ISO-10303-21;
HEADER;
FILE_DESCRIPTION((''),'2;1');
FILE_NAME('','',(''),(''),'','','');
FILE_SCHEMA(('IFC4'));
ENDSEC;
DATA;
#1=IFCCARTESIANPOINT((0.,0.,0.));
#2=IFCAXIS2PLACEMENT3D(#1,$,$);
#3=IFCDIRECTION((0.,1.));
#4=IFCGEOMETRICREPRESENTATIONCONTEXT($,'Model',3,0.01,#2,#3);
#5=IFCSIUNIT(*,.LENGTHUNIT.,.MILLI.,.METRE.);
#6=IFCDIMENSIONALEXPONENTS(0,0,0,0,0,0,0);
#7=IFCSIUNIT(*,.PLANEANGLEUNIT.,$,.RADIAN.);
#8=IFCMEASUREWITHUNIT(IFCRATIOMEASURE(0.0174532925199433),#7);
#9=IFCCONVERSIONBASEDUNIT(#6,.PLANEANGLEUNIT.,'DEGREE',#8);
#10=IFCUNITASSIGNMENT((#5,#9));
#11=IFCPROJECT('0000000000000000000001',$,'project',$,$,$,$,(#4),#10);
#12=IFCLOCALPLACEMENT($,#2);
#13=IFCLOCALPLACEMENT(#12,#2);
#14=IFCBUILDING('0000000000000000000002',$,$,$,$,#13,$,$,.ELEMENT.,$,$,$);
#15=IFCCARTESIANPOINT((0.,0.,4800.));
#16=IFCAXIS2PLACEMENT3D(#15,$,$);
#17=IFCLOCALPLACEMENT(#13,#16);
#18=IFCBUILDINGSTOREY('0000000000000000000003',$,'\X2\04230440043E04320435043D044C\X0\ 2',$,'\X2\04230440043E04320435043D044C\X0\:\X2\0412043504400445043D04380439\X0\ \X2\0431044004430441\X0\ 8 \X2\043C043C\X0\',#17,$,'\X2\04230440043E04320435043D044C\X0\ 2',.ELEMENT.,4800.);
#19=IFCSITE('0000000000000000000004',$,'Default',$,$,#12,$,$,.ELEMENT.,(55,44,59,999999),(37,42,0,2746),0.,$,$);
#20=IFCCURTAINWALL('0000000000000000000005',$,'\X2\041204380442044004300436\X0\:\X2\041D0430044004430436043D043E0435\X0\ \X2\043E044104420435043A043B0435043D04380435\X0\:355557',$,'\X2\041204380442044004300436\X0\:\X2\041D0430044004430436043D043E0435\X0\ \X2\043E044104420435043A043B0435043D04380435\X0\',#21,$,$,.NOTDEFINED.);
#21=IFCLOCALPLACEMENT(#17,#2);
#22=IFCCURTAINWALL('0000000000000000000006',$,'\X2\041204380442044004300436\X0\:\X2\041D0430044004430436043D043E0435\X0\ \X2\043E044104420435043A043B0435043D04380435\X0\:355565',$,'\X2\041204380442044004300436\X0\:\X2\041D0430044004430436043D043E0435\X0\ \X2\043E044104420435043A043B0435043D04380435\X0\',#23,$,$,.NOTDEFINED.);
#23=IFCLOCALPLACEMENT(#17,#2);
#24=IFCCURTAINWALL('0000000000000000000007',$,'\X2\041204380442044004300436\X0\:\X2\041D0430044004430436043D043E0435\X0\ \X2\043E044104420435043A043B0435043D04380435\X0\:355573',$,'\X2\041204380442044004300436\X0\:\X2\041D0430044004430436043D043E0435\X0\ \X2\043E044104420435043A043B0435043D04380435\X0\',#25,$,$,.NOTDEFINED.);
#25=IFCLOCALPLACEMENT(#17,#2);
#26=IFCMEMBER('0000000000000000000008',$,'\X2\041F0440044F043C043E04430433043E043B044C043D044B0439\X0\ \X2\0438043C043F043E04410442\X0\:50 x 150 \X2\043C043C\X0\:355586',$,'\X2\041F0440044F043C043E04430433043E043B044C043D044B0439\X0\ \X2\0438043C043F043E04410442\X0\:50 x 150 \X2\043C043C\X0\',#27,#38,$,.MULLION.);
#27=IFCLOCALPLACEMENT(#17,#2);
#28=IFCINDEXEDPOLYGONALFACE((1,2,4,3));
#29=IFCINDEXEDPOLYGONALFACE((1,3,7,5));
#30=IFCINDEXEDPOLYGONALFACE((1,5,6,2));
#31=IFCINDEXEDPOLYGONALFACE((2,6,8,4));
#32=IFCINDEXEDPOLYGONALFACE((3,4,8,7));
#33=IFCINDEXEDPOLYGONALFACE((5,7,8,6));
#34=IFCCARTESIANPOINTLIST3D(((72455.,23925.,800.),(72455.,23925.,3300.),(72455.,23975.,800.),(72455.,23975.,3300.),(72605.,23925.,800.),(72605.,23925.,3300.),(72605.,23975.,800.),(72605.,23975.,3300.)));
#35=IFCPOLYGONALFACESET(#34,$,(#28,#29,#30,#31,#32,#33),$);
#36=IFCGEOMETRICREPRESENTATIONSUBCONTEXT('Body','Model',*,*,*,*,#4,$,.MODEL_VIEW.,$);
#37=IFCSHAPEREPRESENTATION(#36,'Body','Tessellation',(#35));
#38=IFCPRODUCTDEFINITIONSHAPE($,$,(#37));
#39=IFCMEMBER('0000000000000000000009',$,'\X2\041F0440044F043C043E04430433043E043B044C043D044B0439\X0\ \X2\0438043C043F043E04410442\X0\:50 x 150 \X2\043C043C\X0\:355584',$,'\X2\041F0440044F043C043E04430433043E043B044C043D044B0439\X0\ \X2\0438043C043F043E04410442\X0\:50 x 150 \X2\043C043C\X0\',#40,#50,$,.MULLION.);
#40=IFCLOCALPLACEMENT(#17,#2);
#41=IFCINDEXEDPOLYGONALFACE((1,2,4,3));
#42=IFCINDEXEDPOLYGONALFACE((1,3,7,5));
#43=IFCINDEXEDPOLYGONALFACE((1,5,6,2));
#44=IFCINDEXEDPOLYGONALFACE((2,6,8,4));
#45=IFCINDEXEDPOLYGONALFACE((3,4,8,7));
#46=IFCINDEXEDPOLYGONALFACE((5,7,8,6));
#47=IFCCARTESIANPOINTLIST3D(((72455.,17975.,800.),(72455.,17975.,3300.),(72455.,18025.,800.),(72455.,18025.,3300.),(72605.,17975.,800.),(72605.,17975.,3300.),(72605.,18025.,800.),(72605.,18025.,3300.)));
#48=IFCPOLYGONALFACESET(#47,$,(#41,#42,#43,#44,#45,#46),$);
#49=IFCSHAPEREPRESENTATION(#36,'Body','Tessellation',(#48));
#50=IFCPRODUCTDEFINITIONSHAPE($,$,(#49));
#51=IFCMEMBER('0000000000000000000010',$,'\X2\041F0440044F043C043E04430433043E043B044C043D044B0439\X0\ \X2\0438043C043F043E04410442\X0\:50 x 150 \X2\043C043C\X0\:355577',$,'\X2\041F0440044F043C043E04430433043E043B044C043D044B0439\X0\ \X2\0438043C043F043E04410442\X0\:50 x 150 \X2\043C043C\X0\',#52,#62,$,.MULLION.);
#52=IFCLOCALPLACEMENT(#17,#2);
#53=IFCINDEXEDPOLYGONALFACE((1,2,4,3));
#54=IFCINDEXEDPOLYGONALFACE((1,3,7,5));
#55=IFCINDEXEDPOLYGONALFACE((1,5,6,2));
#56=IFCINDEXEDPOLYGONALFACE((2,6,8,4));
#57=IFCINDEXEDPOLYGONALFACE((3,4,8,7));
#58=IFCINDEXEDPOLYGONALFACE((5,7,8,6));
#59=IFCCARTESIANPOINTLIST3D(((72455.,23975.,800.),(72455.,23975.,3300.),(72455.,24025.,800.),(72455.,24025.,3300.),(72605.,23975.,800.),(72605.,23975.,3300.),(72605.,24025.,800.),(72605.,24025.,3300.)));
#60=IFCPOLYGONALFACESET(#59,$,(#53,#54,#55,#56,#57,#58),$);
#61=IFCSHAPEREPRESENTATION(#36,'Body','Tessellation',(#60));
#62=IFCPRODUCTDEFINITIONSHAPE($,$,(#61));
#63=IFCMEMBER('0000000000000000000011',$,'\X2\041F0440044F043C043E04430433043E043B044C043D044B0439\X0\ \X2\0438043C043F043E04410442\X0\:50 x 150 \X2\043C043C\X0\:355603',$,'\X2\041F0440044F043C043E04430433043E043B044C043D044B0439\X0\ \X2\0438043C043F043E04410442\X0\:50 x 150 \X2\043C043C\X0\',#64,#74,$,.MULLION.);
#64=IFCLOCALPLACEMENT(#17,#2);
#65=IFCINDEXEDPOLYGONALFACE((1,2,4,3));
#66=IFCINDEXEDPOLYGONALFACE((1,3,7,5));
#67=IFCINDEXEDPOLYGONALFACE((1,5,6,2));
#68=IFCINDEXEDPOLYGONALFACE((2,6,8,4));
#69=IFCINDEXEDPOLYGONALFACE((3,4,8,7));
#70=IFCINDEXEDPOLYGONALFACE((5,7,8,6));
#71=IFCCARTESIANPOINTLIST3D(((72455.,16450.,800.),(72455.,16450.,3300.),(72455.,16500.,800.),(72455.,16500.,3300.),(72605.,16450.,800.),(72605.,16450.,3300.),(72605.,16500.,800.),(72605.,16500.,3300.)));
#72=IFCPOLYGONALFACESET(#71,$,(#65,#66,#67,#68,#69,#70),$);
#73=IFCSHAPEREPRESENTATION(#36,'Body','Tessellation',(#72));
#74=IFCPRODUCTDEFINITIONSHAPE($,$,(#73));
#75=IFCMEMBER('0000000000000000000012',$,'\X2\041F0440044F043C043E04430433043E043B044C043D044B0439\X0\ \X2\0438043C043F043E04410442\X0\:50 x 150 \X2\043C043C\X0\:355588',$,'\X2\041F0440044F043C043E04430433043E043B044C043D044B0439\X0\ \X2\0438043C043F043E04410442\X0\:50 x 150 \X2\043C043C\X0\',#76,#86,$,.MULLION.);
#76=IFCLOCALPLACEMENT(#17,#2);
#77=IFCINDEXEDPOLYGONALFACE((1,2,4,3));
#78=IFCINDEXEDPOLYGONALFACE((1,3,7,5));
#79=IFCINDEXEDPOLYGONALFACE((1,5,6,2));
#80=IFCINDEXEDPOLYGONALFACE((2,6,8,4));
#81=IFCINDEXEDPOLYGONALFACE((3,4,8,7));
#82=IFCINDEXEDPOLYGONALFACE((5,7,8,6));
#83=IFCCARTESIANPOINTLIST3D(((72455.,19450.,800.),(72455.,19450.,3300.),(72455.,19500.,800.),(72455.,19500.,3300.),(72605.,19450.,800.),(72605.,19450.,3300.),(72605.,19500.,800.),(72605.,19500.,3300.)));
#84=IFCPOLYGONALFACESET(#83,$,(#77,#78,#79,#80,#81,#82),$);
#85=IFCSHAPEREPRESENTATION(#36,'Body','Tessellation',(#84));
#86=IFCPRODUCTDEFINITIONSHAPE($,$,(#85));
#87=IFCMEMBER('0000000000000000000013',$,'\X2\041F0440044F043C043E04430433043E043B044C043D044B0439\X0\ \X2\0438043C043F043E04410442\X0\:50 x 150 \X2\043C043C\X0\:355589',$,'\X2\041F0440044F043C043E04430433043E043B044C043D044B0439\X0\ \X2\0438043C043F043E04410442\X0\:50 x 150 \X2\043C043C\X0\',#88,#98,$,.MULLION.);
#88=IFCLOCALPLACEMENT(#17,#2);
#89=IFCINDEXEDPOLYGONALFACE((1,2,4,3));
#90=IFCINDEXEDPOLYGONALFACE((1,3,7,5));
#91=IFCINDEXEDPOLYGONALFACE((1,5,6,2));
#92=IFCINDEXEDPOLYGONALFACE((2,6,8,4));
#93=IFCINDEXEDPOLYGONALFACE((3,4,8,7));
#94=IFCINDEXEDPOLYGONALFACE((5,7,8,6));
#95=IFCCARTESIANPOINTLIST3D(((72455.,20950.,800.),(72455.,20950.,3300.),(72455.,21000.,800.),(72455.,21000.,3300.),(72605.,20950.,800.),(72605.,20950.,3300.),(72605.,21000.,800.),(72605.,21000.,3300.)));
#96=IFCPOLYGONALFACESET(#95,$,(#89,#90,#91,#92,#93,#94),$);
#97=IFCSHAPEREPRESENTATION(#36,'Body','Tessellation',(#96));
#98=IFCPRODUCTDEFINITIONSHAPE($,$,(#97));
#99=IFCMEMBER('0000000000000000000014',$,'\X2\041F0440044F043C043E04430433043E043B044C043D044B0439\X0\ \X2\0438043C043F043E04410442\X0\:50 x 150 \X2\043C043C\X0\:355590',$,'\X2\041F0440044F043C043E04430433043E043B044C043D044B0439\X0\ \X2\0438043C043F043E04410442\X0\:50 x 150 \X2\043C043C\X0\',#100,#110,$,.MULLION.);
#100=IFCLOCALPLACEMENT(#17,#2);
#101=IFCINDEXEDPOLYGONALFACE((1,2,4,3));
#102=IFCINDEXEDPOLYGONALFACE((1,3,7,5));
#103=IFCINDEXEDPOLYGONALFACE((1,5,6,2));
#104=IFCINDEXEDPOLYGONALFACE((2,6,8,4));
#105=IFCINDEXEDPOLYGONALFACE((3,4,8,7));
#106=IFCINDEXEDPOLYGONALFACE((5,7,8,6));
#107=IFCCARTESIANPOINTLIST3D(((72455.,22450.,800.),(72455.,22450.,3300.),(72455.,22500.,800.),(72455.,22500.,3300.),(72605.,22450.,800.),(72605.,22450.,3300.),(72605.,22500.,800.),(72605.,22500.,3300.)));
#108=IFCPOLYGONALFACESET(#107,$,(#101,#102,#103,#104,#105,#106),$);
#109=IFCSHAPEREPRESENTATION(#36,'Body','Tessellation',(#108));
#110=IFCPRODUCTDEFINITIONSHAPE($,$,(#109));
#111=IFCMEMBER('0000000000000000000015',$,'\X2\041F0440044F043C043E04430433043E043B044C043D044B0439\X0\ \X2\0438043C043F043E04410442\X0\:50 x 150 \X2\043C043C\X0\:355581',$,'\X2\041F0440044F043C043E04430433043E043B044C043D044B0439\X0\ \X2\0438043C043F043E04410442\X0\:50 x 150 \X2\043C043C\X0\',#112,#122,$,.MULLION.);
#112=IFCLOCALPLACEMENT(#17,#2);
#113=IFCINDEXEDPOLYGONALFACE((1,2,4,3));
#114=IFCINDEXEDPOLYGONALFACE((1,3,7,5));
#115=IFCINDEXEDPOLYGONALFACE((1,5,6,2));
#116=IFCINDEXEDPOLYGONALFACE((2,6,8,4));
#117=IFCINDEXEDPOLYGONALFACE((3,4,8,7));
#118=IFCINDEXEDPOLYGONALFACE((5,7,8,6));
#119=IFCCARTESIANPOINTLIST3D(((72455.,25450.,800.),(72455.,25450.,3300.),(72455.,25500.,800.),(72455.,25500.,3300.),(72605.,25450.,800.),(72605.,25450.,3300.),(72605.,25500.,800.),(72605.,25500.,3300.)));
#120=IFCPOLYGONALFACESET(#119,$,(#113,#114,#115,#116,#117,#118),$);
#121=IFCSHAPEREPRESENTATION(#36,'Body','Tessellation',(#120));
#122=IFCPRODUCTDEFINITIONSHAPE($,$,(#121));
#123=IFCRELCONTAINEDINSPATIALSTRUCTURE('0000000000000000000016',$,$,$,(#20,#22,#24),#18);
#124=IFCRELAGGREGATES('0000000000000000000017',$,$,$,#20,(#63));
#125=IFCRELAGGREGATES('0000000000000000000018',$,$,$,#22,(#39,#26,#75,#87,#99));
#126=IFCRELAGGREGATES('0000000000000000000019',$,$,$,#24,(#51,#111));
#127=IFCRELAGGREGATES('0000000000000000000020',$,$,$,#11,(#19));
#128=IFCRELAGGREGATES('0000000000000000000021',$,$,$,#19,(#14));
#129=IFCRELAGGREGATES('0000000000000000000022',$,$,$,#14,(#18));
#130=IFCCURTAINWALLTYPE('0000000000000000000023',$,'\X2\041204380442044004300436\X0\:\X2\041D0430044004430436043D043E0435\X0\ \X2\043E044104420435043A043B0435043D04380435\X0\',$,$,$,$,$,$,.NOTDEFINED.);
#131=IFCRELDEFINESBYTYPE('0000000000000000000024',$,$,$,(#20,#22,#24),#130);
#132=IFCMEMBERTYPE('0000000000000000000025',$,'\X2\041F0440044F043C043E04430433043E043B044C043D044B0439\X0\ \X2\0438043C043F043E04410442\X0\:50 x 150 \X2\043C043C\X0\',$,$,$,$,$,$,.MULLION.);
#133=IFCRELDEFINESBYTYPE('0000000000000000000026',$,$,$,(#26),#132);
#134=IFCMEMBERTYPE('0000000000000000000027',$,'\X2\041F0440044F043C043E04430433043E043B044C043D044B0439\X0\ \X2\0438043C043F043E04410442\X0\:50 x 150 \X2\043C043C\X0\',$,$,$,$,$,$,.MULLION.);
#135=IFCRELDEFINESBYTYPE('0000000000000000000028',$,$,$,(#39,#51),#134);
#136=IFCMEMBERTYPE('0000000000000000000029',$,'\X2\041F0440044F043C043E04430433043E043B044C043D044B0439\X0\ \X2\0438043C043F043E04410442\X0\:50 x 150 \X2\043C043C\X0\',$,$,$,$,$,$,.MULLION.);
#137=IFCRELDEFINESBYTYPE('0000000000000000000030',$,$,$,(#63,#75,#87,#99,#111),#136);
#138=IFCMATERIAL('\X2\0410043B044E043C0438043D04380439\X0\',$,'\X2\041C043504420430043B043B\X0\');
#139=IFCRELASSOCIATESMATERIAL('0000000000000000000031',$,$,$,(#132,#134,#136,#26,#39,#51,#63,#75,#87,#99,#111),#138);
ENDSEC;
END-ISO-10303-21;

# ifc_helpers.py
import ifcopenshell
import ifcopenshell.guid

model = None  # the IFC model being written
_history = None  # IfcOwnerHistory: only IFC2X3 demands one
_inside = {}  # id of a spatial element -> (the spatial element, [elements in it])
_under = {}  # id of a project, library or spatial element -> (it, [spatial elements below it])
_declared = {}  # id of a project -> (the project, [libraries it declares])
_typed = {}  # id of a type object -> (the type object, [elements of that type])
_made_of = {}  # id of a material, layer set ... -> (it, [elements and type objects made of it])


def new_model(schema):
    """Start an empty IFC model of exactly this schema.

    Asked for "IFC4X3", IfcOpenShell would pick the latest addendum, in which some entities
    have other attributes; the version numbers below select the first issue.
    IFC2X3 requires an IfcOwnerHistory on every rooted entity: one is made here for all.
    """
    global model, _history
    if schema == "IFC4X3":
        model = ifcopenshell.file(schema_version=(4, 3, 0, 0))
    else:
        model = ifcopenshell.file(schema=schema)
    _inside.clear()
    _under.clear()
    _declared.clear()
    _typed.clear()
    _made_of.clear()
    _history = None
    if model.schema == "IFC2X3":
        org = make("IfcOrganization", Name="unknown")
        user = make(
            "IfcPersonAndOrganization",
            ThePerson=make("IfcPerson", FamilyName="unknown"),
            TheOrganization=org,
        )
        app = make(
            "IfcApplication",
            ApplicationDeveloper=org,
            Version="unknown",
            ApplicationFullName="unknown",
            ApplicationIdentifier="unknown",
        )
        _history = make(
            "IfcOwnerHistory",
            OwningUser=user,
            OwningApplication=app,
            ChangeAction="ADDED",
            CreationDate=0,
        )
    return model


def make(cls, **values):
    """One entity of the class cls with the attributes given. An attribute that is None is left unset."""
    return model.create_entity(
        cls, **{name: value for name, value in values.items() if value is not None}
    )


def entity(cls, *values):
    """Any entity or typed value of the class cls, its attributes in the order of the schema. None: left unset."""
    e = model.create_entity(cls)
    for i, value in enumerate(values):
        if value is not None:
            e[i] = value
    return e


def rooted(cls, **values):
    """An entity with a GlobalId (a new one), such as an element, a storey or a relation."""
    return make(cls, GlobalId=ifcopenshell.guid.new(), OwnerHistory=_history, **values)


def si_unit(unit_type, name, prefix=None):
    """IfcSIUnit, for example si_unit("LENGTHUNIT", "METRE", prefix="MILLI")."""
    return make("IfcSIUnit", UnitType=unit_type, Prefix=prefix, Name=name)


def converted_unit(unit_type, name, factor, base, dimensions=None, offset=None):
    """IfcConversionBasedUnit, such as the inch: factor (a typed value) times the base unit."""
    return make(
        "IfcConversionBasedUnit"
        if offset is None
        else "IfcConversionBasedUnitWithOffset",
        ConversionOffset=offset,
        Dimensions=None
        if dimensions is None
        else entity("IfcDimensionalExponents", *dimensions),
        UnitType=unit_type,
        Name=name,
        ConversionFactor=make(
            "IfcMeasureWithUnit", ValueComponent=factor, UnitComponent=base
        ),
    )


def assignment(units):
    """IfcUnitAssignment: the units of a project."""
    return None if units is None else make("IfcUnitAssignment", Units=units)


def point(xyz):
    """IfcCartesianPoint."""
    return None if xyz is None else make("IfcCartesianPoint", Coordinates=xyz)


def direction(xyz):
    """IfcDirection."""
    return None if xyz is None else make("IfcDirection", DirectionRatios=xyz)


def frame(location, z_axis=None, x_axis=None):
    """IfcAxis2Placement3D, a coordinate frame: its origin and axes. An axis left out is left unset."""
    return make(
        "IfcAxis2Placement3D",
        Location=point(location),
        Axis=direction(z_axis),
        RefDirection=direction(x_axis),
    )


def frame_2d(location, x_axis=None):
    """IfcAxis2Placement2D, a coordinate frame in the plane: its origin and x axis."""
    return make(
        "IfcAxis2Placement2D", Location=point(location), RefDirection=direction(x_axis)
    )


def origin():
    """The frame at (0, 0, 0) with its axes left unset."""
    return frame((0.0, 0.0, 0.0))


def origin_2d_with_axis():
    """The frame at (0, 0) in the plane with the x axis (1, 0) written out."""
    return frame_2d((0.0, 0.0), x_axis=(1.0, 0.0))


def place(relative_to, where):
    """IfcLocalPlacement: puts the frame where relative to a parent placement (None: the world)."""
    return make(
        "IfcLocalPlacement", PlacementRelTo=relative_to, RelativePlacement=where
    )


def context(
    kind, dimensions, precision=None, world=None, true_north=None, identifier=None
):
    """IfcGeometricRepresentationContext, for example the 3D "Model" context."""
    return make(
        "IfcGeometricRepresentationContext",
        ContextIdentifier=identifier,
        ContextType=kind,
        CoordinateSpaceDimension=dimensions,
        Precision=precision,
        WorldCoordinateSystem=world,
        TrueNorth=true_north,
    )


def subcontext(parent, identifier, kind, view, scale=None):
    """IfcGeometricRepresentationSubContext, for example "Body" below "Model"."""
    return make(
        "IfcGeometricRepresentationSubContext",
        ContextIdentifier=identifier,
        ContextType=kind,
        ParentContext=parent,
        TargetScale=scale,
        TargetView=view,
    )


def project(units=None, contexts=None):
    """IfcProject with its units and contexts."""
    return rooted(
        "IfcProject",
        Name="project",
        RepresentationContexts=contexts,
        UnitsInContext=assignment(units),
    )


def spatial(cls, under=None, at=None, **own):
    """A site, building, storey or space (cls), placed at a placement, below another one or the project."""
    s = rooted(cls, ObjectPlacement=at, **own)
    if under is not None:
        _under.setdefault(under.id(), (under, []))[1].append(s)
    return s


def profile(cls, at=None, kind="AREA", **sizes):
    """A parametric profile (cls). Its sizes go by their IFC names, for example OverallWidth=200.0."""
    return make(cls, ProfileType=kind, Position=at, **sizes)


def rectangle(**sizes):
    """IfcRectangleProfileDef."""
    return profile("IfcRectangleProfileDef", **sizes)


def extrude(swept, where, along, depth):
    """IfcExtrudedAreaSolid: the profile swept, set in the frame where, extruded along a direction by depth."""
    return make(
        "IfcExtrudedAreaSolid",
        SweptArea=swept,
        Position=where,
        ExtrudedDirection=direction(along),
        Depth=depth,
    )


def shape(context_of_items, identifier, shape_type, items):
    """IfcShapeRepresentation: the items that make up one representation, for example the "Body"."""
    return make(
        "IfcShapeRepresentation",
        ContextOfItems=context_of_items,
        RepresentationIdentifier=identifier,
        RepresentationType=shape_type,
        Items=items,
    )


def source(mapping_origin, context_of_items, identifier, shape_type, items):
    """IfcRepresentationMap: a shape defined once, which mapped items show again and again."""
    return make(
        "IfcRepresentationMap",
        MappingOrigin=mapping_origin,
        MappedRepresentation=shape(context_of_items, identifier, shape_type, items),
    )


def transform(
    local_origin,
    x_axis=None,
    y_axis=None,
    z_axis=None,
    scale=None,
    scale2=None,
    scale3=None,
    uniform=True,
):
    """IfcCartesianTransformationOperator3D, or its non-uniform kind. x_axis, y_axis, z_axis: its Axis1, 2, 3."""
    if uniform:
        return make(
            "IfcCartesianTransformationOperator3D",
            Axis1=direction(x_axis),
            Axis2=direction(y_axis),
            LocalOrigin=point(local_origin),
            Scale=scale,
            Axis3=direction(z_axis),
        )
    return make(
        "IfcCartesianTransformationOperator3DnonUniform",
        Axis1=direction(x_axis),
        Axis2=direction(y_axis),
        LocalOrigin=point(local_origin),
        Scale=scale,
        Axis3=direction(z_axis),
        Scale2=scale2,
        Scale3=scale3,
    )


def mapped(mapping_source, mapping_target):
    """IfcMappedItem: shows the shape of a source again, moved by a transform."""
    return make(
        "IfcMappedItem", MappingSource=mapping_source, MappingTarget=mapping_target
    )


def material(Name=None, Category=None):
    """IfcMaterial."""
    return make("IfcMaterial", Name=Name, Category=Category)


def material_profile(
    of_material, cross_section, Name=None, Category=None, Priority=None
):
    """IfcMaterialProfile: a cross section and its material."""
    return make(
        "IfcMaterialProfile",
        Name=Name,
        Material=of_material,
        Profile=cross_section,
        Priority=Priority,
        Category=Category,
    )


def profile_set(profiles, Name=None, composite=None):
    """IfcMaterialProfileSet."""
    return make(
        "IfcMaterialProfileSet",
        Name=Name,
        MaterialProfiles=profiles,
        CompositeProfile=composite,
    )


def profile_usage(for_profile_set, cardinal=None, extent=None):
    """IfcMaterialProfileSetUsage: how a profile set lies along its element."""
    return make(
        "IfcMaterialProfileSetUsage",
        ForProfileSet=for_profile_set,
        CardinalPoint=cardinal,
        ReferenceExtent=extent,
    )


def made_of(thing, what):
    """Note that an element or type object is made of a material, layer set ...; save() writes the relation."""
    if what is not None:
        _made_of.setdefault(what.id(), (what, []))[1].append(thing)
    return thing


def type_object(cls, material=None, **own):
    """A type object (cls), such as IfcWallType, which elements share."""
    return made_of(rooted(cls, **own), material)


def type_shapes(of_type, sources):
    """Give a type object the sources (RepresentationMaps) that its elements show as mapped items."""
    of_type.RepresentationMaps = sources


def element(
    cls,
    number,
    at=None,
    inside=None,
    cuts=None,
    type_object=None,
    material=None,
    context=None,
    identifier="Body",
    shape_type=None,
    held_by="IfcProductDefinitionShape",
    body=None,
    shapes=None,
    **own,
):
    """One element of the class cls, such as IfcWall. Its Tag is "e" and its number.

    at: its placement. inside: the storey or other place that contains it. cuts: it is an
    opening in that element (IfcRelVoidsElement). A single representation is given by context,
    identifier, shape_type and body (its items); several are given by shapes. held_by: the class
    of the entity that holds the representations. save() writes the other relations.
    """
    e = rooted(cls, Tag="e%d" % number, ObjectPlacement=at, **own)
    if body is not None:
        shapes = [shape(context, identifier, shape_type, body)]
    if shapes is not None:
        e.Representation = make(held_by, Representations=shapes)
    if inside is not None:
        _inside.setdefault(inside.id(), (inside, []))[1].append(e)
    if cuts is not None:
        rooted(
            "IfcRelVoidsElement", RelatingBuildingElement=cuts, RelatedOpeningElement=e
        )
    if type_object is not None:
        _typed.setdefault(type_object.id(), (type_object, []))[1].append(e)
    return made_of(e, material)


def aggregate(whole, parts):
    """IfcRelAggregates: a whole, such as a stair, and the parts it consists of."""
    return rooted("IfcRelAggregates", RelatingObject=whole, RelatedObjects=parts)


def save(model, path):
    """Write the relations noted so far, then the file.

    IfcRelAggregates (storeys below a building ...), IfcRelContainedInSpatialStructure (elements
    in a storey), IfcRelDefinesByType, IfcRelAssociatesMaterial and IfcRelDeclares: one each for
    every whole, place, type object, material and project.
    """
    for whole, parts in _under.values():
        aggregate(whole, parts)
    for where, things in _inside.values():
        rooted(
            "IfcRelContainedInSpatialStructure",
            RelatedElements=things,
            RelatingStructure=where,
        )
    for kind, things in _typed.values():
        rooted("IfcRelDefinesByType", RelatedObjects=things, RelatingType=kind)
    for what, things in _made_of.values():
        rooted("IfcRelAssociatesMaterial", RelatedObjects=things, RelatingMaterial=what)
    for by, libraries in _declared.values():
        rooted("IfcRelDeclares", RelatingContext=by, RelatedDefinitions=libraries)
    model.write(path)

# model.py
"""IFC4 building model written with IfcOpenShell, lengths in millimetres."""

from ifc_helpers import new_model, entity, si_unit, converted_unit, direction, frame, origin, origin_2d_with_axis, place, context, subcontext, project, spatial, rectangle, extrude, source, transform, mapped, material, material_profile, profile_set, profile_usage, type_object, type_shapes, element, aggregate, save


model = new_model("IFC4")

# Units and contexts
model_context = context("Model", 3, precision=0.01, world=origin(), true_north=direction((0.0, 1.0)))
body_context = subcontext(model_context, "Body", "Model", "MODEL_VIEW")
ifc_project = project(units=[si_unit("LENGTHUNIT", "METRE", prefix="MILLI"), converted_unit("PLANEANGLEUNIT", "DEGREE", entity("IfcRatioMeasure", 0.0174532925199433), si_unit("PLANEANGLEUNIT", "RADIAN"), dimensions=[0, 0, 0, 0, 0, 0, 0])], contexts=[model_context])

# Site, building, storey
site_placement = place(None, origin())
site = spatial("IfcSite", under=ifc_project, at=site_placement, Name="Default", CompositionType="ELEMENT", RefLatitude=(55, 44, 59, 999999), RefLongitude=(37, 42, 0, 2746), RefElevation=0.0)
building_placement = place(site_placement, origin())
building = spatial("IfcBuilding", under=site, at=building_placement, CompositionType="ELEMENT")
storey_placement = place(building_placement, frame((0.0, 0.0, 4800.0)))
storey = spatial("IfcBuildingStorey", under=building, at=storey_placement, Name="Уровень 2", ObjectType="Уровень:Верхний брус 8 мм", LongName="Уровень 2", CompositionType="ELEMENT", Elevation=4800.0)

# Curtain wall
curtain_wall_type = type_object("IfcCurtainWallType", Name="Витраж:Наружное остекление", PredefinedType="NOTDEFINED")
curtain_wall_1_placement = place(storey_placement, frame((0.0, 0.0, -4800.0)))
curtain_wall_1 = element("IfcCurtainWall", 1, at=curtain_wall_1_placement, inside=storey, type_object=curtain_wall_type, Name="Витраж:Наружное остекление:355557", ObjectType="Витраж:Наружное остекление", PredefinedType="NOTDEFINED")
ifc_material = material(Name="Алюминий", Category="Металл")
ifc_material_profile = material_profile(ifc_material, rectangle(XDim=150.0, YDim=50.0, at=origin_2d_with_axis()), Name="50 x 150 мм")
ifc_profile_set = profile_set([ifc_material_profile], Name="50 x 150 мм")

# Curtain wall
curtain_wall_2_placement = place(storey_placement, frame((0.0, 0.0, -4800.0)))
curtain_wall_2 = element("IfcCurtainWall", 2, at=curtain_wall_2_placement, inside=storey, type_object=curtain_wall_type, Name="Витраж:Наружное остекление:355565", ObjectType="Витраж:Наружное остекление", PredefinedType="NOTDEFINED")

# Curtain wall
curtain_wall_3_placement = place(storey_placement, frame((0.0, 0.0, -4800.0)))
curtain_wall_3 = element("IfcCurtainWall", 3, at=curtain_wall_3_placement, inside=storey, type_object=curtain_wall_type, Name="Витраж:Наружное остекление:355573", ObjectType="Витраж:Наружное остекление", PredefinedType="NOTDEFINED")

# Members
member_type_1 = type_object("IfcMemberType", Name="Прямоугольный импост:50 x 150 мм", PredefinedType="MULLION", material=ifc_profile_set)
shared_shape_1 = source(origin(), body_context, "Body", "SweptSolid", [
    extrude(rectangle(XDim=150.0, YDim=50.0, at=origin_2d_with_axis()), frame((-25.0, 0.0, -2500.0), z_axis=(0.0, 0.0, 1.0), x_axis=(0.0, -1.0, 0.0)), (0.0, 0.0, 1.0), 2500.0),
])
type_shapes(member_type_1, [shared_shape_1])
ifc_profile_usage_1 = profile_usage(ifc_profile_set)
member_1_placement = place(storey_placement, frame((72530.0, 23975.0, 800.0), z_axis=(0.0, 0.0, -1.0), x_axis=(0.0, 1.0, 0.0)))
member_1 = element("IfcMember", 4, at=member_1_placement, type_object=member_type_1, material=ifc_profile_usage_1, Name="Прямоугольный импост:50 x 150 мм:355586", ObjectType="Прямоугольный импост:50 x 150 мм", PredefinedType="MULLION", context=body_context, shape_type="MappedRepresentation", body=[
    mapped(shared_shape_1, transform((0.0, 0.0, 0.0), scale=1.0)),
])
ifc_profile_usage_2 = profile_usage(ifc_profile_set)
member_type_2 = type_object("IfcMemberType", Name="Прямоугольный импост:50 x 150 мм", PredefinedType="MULLION", material=ifc_profile_set)
shared_shape_2 = source(origin(), body_context, "Body", "SweptSolid", [
    extrude(rectangle(XDim=150.0, YDim=50.0, at=origin_2d_with_axis()), frame((-25.0, 0.0, -2500.0), z_axis=(0.0, 0.0, 1.0), x_axis=(0.0, -1.0, 0.0)), (0.0, 0.0, 1.0), 2500.0),
])
type_shapes(member_type_2, [shared_shape_2])
member_2_placement = place(storey_placement, frame((72530.0, 17975.0, 3300.0), z_axis=(0.0, 0.0, 1.0), x_axis=(0.0, -1.0, 0.0)))
member_2 = element("IfcMember", 5, at=member_2_placement, type_object=member_type_2, material=ifc_profile_usage_2, Name="Прямоугольный импост:50 x 150 мм:355584", ObjectType="Прямоугольный импост:50 x 150 мм", PredefinedType="MULLION", context=body_context, shape_type="MappedRepresentation", body=[
    mapped(shared_shape_2, transform((0.0, 0.0, 0.0), scale=1.0)),
])
ifc_profile_usage_3 = profile_usage(ifc_profile_set)
member_3_placement = place(storey_placement, frame((72530.0, 23975.0, 3300.0), z_axis=(0.0, 0.0, 1.0), x_axis=(0.0, -1.0, 0.0)))
member_3 = element("IfcMember", 6, at=member_3_placement, type_object=member_type_2, material=ifc_profile_usage_3, Name="Прямоугольный импост:50 x 150 мм:355577", ObjectType="Прямоугольный импост:50 x 150 мм", PredefinedType="MULLION", context=body_context, shape_type="MappedRepresentation", body=[
    mapped(shared_shape_2, transform((0.0, 0.0, 0.0), scale=1.0)),
])
ifc_profile_usage_4 = profile_usage(ifc_profile_set)
member_type_3 = type_object("IfcMemberType", Name="Прямоугольный импост:50 x 150 мм", PredefinedType="MULLION", material=ifc_profile_set)
shared_shape_3 = source(origin(), body_context, "Body", "SweptSolid", [
    extrude(rectangle(XDim=150.0, YDim=50.0, at=origin_2d_with_axis()), frame((0.0, 0.0, -2500.0), z_axis=(0.0, 0.0, 1.0), x_axis=(0.0, -1.0, 0.0)), (0.0, 0.0, 1.0), 2500.0),
])
type_shapes(member_type_3, [shared_shape_3])
member_4_placement = place(storey_placement, frame((72530.0, 16475.0, 800.0), z_axis=(0.0, 0.0, -1.0), x_axis=(0.0, 1.0, 0.0)))
member_4 = element("IfcMember", 7, at=member_4_placement, type_object=member_type_3, material=ifc_profile_usage_4, Name="Прямоугольный импост:50 x 150 мм:355603", ObjectType="Прямоугольный импост:50 x 150 мм", PredefinedType="MULLION", context=body_context, shape_type="MappedRepresentation", body=[
    mapped(shared_shape_3, transform((0.0, 0.0, 0.0), scale=1.0)),
])
aggregate(curtain_wall_1, [member_4])
ifc_profile_usage_5 = profile_usage(ifc_profile_set)
member_5_placement = place(storey_placement, frame((72530.0, 19475.0, 800.0), z_axis=(0.0, 0.0, -1.0), x_axis=(0.0, 1.0, 0.0)))
member_5 = element("IfcMember", 8, at=member_5_placement, type_object=member_type_3, material=ifc_profile_usage_5, Name="Прямоугольный импост:50 x 150 мм:355588", ObjectType="Прямоугольный импост:50 x 150 мм", PredefinedType="MULLION", context=body_context, shape_type="MappedRepresentation", body=[
    mapped(shared_shape_3, transform((0.0, 0.0, 0.0), scale=1.0)),
])
ifc_profile_usage_6 = profile_usage(ifc_profile_set)
member_6_placement = place(storey_placement, frame((72530.0, 20975.0, 800.0), z_axis=(0.0, 0.0, -1.0), x_axis=(0.0, 1.0, 0.0)))
member_6 = element("IfcMember", 9, at=member_6_placement, type_object=member_type_3, material=ifc_profile_usage_6, Name="Прямоугольный импост:50 x 150 мм:355589", ObjectType="Прямоугольный импост:50 x 150 мм", PredefinedType="MULLION", context=body_context, shape_type="MappedRepresentation", body=[
    mapped(shared_shape_3, transform((0.0, 0.0, 0.0), scale=1.0)),
])
ifc_profile_usage_7 = profile_usage(ifc_profile_set)
member_7_placement = place(storey_placement, frame((72530.0, 22475.0, 800.0), z_axis=(0.0, 0.0, -1.0), x_axis=(0.0, 1.0, 0.0)))
member_7 = element("IfcMember", 10, at=member_7_placement, type_object=member_type_3, material=ifc_profile_usage_7, Name="Прямоугольный импост:50 x 150 мм:355590", ObjectType="Прямоугольный импост:50 x 150 мм", PredefinedType="MULLION", context=body_context, shape_type="MappedRepresentation", body=[
    mapped(shared_shape_3, transform((0.0, 0.0, 0.0), scale=1.0)),
])
aggregate(curtain_wall_2, [member_2, member_1, member_5, member_6, member_7])
ifc_profile_usage_8 = profile_usage(ifc_profile_set)
member_8_placement = place(storey_placement, frame((72530.0, 25475.0, 800.0), z_axis=(0.0, 0.0, -1.0), x_axis=(0.0, 1.0, 0.0)))
member_8 = element("IfcMember", 11, at=member_8_placement, type_object=member_type_3, material=ifc_profile_usage_8, Name="Прямоугольный импост:50 x 150 мм:355581", ObjectType="Прямоугольный импост:50 x 150 мм", PredefinedType="MULLION", context=body_context, shape_type="MappedRepresentation", body=[
    mapped(shared_shape_3, transform((0.0, 0.0, 0.0), scale=1.0)),
])
aggregate(curtain_wall_3, [member_3, member_8])

save(model, "model.ifc")
